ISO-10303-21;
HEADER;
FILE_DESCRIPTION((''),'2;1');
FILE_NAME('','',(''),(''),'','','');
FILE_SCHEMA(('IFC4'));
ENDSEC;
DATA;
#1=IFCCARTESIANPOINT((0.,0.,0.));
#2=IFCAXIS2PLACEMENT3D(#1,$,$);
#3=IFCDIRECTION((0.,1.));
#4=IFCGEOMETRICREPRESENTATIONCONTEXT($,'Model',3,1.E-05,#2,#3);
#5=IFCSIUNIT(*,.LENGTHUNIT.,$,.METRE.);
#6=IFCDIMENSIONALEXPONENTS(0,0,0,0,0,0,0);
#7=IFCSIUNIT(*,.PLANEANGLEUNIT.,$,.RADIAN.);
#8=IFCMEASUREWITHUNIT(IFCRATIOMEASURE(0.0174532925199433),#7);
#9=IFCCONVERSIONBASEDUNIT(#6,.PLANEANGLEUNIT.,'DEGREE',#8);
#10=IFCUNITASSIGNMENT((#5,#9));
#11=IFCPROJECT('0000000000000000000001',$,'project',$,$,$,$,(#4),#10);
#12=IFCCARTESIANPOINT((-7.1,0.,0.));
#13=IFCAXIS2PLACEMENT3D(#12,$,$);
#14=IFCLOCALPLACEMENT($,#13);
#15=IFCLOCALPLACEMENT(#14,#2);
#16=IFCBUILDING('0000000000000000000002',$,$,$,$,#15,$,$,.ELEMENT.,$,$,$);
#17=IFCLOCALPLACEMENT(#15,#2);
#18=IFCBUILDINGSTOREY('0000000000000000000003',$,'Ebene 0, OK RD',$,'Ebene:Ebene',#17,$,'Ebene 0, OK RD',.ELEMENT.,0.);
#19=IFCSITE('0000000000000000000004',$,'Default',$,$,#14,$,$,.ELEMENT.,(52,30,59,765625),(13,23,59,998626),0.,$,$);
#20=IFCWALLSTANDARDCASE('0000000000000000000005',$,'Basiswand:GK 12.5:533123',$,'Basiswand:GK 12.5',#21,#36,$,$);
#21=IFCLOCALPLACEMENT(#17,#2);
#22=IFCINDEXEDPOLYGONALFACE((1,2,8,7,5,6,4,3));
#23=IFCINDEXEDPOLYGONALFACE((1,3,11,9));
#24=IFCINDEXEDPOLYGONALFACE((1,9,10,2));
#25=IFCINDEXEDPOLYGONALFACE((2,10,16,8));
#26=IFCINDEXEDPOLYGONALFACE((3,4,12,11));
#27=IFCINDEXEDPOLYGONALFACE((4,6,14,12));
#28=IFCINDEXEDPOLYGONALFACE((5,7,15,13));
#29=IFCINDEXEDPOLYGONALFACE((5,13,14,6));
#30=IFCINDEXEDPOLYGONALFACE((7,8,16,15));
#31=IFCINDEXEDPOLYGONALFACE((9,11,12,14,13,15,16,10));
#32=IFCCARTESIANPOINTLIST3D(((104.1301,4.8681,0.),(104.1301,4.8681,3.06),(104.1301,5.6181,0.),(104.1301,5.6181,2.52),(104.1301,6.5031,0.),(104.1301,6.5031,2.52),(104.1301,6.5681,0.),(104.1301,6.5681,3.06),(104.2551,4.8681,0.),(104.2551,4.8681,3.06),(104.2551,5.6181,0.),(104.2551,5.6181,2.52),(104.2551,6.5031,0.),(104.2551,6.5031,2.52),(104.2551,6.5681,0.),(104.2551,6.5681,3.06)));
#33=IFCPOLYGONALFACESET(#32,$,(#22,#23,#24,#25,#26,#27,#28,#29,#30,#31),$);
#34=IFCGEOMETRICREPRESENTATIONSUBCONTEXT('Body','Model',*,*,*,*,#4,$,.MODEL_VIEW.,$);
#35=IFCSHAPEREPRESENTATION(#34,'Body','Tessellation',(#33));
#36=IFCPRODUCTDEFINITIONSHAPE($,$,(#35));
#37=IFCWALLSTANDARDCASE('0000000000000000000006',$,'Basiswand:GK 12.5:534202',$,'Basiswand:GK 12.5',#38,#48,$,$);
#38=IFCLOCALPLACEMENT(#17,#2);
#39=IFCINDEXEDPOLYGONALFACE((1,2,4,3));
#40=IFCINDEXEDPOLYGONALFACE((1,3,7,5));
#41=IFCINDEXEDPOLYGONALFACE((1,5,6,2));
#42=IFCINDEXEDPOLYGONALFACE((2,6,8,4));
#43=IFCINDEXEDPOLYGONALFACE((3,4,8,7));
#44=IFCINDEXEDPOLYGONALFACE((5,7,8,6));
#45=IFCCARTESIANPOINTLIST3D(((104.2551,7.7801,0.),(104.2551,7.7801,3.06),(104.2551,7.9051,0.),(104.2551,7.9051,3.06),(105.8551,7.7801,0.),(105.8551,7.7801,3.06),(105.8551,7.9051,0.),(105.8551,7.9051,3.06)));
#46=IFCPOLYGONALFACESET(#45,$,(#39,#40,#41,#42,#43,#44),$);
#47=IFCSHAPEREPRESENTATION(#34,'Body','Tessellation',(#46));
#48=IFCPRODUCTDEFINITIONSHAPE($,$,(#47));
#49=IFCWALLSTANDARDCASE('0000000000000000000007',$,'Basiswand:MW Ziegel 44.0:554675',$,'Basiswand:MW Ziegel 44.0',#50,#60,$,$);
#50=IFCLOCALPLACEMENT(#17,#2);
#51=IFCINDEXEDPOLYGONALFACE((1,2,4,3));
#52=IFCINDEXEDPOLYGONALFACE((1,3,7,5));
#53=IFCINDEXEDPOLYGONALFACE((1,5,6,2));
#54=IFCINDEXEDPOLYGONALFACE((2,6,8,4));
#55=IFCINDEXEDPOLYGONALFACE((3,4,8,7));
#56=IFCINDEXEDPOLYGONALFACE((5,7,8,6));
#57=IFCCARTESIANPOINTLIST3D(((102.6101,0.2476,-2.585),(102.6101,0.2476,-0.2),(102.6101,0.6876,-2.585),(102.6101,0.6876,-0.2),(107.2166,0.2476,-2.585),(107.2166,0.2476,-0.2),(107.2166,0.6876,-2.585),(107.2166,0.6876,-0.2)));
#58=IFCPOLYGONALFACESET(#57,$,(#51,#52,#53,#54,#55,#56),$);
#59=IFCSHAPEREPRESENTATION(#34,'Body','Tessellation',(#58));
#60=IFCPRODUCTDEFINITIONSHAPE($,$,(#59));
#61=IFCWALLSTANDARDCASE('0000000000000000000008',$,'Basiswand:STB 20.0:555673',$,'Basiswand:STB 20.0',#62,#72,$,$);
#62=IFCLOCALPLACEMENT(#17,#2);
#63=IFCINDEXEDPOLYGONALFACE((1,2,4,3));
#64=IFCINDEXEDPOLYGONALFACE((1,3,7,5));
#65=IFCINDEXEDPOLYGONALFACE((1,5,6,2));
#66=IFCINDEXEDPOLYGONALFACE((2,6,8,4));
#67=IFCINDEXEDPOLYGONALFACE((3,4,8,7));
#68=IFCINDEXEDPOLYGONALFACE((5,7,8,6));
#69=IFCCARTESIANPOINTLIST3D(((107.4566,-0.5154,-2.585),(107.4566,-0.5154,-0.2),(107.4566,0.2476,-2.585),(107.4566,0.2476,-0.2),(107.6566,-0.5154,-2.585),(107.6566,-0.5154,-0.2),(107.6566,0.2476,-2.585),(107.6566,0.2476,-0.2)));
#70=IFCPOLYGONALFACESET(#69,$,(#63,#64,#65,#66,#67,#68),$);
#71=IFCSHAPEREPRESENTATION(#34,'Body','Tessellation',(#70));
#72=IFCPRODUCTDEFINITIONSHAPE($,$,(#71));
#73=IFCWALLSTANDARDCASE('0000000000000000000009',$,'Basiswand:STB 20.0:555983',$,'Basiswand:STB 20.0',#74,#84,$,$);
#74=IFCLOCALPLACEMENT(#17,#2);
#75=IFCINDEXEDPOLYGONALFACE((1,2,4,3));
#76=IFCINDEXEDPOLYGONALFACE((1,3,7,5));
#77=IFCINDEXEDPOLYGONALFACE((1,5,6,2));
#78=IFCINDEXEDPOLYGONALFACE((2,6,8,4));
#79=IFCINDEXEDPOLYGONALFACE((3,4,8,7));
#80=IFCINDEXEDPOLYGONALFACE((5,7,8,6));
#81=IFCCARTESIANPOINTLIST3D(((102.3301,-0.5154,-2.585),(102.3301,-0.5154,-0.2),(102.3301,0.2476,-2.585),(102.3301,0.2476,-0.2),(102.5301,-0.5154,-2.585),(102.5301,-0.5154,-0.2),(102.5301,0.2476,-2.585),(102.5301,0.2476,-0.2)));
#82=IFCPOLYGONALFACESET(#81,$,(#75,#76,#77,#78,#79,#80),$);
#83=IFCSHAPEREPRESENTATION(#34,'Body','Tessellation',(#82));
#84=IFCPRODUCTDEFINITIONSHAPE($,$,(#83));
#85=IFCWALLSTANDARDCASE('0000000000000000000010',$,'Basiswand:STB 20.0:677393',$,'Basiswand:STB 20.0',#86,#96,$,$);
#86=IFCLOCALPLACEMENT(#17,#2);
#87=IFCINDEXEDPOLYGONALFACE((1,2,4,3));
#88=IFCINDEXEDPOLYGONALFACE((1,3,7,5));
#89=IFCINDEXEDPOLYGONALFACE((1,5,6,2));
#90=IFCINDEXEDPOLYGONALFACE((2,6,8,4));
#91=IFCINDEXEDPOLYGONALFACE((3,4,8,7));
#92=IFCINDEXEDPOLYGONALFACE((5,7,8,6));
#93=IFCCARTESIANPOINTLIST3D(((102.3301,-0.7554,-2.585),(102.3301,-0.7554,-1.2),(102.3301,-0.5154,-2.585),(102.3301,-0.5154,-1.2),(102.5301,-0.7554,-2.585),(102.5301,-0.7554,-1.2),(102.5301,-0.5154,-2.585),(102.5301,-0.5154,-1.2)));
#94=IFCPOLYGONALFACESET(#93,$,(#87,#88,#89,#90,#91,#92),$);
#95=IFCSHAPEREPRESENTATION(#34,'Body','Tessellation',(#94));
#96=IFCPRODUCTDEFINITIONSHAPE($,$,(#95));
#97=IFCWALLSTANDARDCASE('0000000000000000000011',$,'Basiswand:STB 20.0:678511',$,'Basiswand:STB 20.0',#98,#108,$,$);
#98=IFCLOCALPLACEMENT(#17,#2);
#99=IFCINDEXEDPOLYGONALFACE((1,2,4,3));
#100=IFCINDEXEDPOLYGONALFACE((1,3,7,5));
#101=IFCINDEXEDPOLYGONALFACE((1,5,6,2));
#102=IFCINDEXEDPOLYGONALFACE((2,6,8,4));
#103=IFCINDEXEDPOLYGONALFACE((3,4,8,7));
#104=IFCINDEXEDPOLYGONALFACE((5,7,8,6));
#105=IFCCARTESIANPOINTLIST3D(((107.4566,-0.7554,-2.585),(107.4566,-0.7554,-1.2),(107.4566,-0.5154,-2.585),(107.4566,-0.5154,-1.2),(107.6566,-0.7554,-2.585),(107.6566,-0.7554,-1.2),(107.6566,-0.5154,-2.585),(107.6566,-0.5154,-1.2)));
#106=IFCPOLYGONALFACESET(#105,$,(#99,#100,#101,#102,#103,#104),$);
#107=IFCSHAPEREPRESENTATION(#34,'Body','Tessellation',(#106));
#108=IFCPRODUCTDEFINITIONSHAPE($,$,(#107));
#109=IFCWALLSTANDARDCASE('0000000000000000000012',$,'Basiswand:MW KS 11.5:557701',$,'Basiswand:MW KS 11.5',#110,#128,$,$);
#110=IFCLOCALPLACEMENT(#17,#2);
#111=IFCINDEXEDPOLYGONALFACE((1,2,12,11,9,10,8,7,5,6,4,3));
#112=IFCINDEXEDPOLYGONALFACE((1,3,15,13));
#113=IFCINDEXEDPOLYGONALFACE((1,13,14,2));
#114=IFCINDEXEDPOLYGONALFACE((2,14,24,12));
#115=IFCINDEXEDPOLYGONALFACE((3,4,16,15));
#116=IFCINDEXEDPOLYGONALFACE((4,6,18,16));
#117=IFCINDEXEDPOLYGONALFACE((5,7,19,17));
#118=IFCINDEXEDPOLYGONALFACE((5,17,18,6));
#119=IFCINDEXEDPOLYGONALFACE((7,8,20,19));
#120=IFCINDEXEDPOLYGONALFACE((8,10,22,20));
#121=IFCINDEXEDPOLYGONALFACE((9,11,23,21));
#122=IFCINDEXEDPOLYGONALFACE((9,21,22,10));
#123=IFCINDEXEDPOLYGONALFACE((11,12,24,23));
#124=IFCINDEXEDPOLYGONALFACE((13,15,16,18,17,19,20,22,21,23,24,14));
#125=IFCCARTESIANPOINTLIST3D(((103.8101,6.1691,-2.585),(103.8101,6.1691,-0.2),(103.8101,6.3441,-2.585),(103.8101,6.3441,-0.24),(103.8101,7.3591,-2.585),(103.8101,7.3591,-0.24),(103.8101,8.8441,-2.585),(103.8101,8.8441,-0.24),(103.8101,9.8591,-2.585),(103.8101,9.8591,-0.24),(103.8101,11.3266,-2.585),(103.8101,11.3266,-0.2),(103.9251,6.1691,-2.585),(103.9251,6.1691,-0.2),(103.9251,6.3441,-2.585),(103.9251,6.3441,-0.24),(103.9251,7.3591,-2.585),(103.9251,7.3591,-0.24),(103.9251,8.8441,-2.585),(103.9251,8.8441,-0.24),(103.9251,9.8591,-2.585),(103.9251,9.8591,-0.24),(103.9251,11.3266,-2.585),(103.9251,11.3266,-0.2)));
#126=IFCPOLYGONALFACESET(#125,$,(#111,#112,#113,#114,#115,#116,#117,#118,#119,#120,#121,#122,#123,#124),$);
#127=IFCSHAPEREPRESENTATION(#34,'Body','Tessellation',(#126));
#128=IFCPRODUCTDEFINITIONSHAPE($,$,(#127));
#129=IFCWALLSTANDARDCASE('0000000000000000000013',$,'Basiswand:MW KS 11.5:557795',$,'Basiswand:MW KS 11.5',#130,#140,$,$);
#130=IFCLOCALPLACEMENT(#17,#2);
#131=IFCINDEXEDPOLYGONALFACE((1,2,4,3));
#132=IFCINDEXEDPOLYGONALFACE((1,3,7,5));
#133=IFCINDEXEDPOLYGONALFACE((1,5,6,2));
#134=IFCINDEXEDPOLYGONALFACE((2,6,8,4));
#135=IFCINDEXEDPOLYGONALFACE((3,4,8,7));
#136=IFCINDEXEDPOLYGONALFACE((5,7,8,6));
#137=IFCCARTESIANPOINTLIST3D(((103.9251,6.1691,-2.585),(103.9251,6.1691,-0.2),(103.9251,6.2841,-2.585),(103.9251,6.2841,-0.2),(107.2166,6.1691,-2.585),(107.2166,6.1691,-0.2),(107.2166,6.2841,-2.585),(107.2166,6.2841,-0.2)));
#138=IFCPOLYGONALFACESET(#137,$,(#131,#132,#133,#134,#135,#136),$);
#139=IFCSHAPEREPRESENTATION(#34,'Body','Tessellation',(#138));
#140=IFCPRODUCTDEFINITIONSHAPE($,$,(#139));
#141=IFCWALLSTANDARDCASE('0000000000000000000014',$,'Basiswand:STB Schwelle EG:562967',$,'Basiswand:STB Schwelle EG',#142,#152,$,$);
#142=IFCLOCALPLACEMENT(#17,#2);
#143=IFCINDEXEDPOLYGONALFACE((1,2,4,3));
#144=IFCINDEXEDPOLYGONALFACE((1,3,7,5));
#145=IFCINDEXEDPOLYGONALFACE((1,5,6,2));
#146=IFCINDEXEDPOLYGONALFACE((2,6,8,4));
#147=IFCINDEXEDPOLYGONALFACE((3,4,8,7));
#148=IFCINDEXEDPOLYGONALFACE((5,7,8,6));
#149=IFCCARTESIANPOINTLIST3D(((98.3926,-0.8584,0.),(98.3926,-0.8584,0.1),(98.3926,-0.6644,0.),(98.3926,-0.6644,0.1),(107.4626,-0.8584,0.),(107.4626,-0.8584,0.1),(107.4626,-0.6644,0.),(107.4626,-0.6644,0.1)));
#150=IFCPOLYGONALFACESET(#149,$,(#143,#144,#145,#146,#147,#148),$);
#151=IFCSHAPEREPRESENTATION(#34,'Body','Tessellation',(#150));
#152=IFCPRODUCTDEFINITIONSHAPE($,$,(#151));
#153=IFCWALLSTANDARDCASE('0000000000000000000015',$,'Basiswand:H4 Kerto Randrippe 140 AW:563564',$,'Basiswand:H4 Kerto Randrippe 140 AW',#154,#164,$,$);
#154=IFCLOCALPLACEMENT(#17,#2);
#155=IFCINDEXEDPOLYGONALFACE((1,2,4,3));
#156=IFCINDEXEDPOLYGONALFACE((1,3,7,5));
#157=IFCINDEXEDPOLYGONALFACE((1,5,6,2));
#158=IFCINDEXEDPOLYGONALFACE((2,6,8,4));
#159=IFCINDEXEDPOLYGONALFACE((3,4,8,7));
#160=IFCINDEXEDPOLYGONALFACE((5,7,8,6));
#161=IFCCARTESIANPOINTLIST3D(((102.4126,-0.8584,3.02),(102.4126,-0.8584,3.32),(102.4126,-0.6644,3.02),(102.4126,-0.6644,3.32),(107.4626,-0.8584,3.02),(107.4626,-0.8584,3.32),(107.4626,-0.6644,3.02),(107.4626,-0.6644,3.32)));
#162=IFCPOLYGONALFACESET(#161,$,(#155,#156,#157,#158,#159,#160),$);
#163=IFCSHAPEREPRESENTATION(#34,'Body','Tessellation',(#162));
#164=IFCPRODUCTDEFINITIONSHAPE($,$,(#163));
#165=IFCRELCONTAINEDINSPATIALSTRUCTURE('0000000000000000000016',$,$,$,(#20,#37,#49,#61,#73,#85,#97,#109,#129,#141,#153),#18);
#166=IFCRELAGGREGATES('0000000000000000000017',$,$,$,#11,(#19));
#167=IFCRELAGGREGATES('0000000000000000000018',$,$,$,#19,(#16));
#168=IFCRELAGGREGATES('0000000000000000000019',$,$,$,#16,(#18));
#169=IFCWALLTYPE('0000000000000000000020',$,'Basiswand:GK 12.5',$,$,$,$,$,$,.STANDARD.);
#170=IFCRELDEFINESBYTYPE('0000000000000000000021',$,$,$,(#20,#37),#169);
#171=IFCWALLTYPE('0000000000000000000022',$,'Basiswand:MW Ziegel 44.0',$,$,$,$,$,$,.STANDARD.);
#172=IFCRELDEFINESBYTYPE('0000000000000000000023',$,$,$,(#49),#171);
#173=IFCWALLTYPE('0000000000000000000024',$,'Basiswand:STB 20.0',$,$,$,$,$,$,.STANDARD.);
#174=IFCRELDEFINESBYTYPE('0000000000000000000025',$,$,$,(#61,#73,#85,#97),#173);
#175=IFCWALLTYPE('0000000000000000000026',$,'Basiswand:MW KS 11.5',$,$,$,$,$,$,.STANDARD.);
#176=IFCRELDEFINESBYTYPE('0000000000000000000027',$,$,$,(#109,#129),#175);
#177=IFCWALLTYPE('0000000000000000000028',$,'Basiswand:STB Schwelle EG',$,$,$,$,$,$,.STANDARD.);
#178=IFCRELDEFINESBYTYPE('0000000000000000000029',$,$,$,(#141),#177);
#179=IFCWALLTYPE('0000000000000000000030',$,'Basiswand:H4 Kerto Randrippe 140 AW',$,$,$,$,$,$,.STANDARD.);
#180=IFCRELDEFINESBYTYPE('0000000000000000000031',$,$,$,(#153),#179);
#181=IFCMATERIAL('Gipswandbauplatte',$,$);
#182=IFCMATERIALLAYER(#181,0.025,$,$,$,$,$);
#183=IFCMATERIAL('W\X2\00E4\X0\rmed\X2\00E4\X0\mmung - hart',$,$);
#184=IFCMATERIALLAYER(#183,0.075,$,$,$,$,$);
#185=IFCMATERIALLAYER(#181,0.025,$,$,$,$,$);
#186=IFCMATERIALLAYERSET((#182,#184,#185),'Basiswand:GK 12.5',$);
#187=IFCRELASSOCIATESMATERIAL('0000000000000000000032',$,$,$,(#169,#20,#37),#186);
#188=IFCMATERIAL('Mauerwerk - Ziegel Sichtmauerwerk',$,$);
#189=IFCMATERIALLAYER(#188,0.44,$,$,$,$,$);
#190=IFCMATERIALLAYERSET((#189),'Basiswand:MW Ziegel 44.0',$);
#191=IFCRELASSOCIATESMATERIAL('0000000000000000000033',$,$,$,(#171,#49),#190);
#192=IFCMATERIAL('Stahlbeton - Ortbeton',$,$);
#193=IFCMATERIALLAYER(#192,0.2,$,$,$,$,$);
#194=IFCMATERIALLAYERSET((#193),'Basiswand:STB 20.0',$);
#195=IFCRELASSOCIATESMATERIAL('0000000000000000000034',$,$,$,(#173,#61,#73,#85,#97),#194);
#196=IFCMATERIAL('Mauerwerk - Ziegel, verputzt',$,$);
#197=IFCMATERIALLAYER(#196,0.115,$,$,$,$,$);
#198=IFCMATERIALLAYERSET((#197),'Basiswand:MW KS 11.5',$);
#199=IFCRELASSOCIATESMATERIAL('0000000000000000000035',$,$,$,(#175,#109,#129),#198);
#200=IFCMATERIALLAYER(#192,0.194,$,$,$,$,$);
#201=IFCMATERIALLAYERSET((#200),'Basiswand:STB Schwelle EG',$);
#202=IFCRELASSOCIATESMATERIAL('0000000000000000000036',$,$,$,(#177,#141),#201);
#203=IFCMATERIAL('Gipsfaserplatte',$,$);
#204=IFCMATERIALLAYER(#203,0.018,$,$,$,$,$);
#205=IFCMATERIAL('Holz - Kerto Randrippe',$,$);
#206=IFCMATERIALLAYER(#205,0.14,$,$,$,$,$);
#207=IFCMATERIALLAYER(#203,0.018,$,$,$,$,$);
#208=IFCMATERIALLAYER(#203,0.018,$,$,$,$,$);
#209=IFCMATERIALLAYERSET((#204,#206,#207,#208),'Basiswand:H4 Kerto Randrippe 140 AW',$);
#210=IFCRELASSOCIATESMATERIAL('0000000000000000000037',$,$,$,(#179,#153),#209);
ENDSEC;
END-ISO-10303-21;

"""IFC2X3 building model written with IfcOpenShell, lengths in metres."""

from ifc_helpers import new_model, entity, si_unit, converted_unit, direction, frame, frame_2d, origin, place, context, subcontext, project, spatial, rectangle, extrude, material, layer, layer_set, layer_usage, type_object, element, save


model = new_model("IFC2X3")

# Units and contexts
model_context = context("Model", 3, precision=1e-05, world=origin(), true_north=direction((0.0, 1.0)))
body_context = subcontext(model_context, "Body", "Model", "MODEL_VIEW")
ifc_project = project(units=[si_unit("LENGTHUNIT", "METRE"), converted_unit("PLANEANGLEUNIT", "DEGREE", entity("IfcRatioMeasure", 0.0174532925199433), si_unit("PLANEANGLEUNIT", "RADIAN"), dimensions=[0, 0, 0, 0, 0, 0, 0])], contexts=[model_context])

# Site, building, storey
site_placement = place(None, frame((-7.1, 0.0, 0.0)))
site = spatial("IfcSite", under=ifc_project, at=site_placement, Name="Default", CompositionType="ELEMENT", RefLatitude=(52, 30, 59, 765625), RefLongitude=(13, 23, 59, 998626), RefElevation=0.0)
building_placement = place(site_placement, origin())
building = spatial("IfcBuilding", under=site, at=building_placement, CompositionType="ELEMENT")
storey_placement = place(building_placement, origin())
storey = spatial("IfcBuildingStorey", under=building, at=storey_placement, Name="Ebene 0, OK RD", ObjectType="Ebene:Ebene", LongName="Ebene 0, OK RD", CompositionType="ELEMENT", Elevation=0.0)

# Shared definitions
ifc_material_1 = material(Name="Gipsfaserplatte")

# Shared definitions
ifc_material_2 = material(Name="Gipswandbauplatte")
ifc_layer_1 = layer(ifc_material_2, 0.025)
ifc_material_3 = material(Name="Wärmedämmung - hart")
ifc_layer_2 = layer(ifc_material_3, 0.075)
ifc_layer_3 = layer(ifc_material_2, 0.025)
ifc_layer_set_1 = layer_set([ifc_layer_1, ifc_layer_2, ifc_layer_3], Name="Basiswand:GK 12.5")
wall_type_1 = type_object("IfcWallType", Name="Basiswand:GK 12.5", PredefinedType="STANDARD", material=ifc_layer_set_1)

# Wall, opening
ifc_layer_usage_1 = layer_usage(ifc_layer_set_1, "AXIS2", "NEGATIVE", 0.0625)
wall_1_placement = place(storey_placement, frame((104.1926, 6.5681, 0.0), z_axis=(0.0, 0.0, 1.0), x_axis=(0.0, -1.0, 0.0)))
wall_1 = element("IfcWallStandardCase", 1, at=wall_1_placement, inside=storey, type_object=wall_type_1, material=ifc_layer_usage_1, Name="Basiswand:GK 12.5:533123", ObjectType="Basiswand:GK 12.5", context=body_context, shape_type="SweptSolid", body=[
    extrude(rectangle(XDim=1.7, YDim=0.125, at=frame_2d((0.85, 0.0), x_axis=(-1.0, 0.0))), origin(), (0.0, 0.0, 1.0), 3.06),
])
opening_1_placement = place(wall_1_placement, frame((0.065, -0.0625, 0.0)))
element("IfcOpeningElement", 2, at=opening_1_placement, cuts=wall_1, ObjectType="Opening", context=body_context, shape_type="SweptSolid", body=[
    extrude(rectangle(XDim=2.52, YDim=0.885, at=frame_2d((1.26, 0.4425), x_axis=(1.0, 0.0))), frame((0.0, 0.0, 0.0), z_axis=(0.0, 1.0, 0.0), x_axis=(0.0, 0.0, 1.0)), (0.0, 0.0, 1.0), 0.125),
])

# Walls
ifc_layer_usage_2 = layer_usage(ifc_layer_set_1, "AXIS2", "NEGATIVE", 0.0625)
wall_2_placement = place(storey_placement, frame((104.2551, 7.8426, 0.0)))
element("IfcWallStandardCase", 3, at=wall_2_placement, inside=storey, type_object=wall_type_1, material=ifc_layer_usage_2, Name="Basiswand:GK 12.5:534202", ObjectType="Basiswand:GK 12.5", context=body_context, shape_type="SweptSolid", body=[
    extrude(rectangle(XDim=1.6, YDim=0.125, at=frame_2d((0.8, 0.0), x_axis=(-1.0, 0.0))), origin(), (0.0, 0.0, 1.0), 3.06),
])
ifc_material_4 = material(Name="Mauerwerk - Ziegel Sichtmauerwerk")
ifc_layer_4 = layer(ifc_material_4, 0.44)
ifc_layer_set_2 = layer_set([ifc_layer_4], Name="Basiswand:MW Ziegel 44.0")
ifc_layer_usage_3 = layer_usage(ifc_layer_set_2, "AXIS2", "NEGATIVE", 0.22)
wall_type_2 = type_object("IfcWallType", Name="Basiswand:MW Ziegel 44.0", PredefinedType="STANDARD", material=ifc_layer_set_2)
wall_3_placement = place(storey_placement, frame((107.2166, 0.4676, -2.585), z_axis=(0.0, 0.0, 1.0), x_axis=(-1.0, 0.0, 0.0)))
element("IfcWallStandardCase", 4, at=wall_3_placement, inside=storey, type_object=wall_type_2, material=ifc_layer_usage_3, Name="Basiswand:MW Ziegel 44.0:554675", ObjectType="Basiswand:MW Ziegel 44.0", context=body_context, shape_type="SweptSolid", body=[
    extrude(rectangle(XDim=4.6065, YDim=0.44, at=frame_2d((2.3033, 0.0), x_axis=(-1.0, 0.0))), origin(), (0.0, 0.0, 1.0), 2.385),
])
ifc_material_5 = material(Name="Stahlbeton - Ortbeton")
ifc_layer_5 = layer(ifc_material_5, 0.2)
ifc_layer_set_3 = layer_set([ifc_layer_5], Name="Basiswand:STB 20.0")
ifc_layer_usage_4 = layer_usage(ifc_layer_set_3, "AXIS2", "NEGATIVE", 0.1)
wall_type_3 = type_object("IfcWallType", Name="Basiswand:STB 20.0", PredefinedType="STANDARD", material=ifc_layer_set_3)
wall_4_placement = place(storey_placement, frame((107.5566, 0.2476, -2.585), z_axis=(0.0, 0.0, 1.0), x_axis=(0.0, -1.0, 0.0)))
element("IfcWallStandardCase", 5, at=wall_4_placement, inside=storey, type_object=wall_type_3, material=ifc_layer_usage_4, Name="Basiswand:STB 20.0:555673", ObjectType="Basiswand:STB 20.0", context=body_context, shape_type="SweptSolid", body=[
    extrude(rectangle(XDim=0.763, YDim=0.2, at=frame_2d((0.3815, 0.0), x_axis=(-1.0, 0.0))), origin(), (0.0, 0.0, 1.0), 2.385),
])
ifc_layer_usage_5 = layer_usage(ifc_layer_set_3, "AXIS2", "NEGATIVE", 0.1)
wall_5_placement = place(storey_placement, frame((102.4301, 0.2476, -2.585), z_axis=(0.0, 0.0, 1.0), x_axis=(0.0, -1.0, 0.0)))
element("IfcWallStandardCase", 6, at=wall_5_placement, inside=storey, type_object=wall_type_3, material=ifc_layer_usage_5, Name="Basiswand:STB 20.0:555983", ObjectType="Basiswand:STB 20.0", context=body_context, shape_type="SweptSolid", body=[
    extrude(rectangle(XDim=0.763, YDim=0.2, at=frame_2d((0.3815, 0.0), x_axis=(-1.0, 0.0))), origin(), (0.0, 0.0, 1.0), 2.385),
])
ifc_layer_usage_6 = layer_usage(ifc_layer_set_3, "AXIS2", "NEGATIVE", 0.1)
wall_6_placement = place(storey_placement, frame((102.4301, -0.5154, -2.585), z_axis=(0.0, 0.0, 1.0), x_axis=(0.0, -1.0, 0.0)))
element("IfcWallStandardCase", 7, at=wall_6_placement, inside=storey, type_object=wall_type_3, material=ifc_layer_usage_6, Name="Basiswand:STB 20.0:677393", ObjectType="Basiswand:STB 20.0", context=body_context, shape_type="SweptSolid", body=[
    extrude(rectangle(XDim=0.24, YDim=0.2, at=frame_2d((0.12, 0.0), x_axis=(-1.0, 0.0))), origin(), (0.0, 0.0, 1.0), 1.385),
])
ifc_layer_usage_7 = layer_usage(ifc_layer_set_3, "AXIS2", "NEGATIVE", 0.1)
wall_7_placement = place(storey_placement, frame((107.5566, -0.5154, -2.585), z_axis=(0.0, 0.0, 1.0), x_axis=(0.0, -1.0, 0.0)))
element("IfcWallStandardCase", 8, at=wall_7_placement, inside=storey, type_object=wall_type_3, material=ifc_layer_usage_7, Name="Basiswand:STB 20.0:678511", ObjectType="Basiswand:STB 20.0", context=body_context, shape_type="SweptSolid", body=[
    extrude(rectangle(XDim=0.24, YDim=0.2, at=frame_2d((0.12, 0.0), x_axis=(-1.0, 0.0))), origin(), (0.0, 0.0, 1.0), 1.385),
])

# Wall, openings
ifc_material_6 = material(Name="Mauerwerk - Ziegel, verputzt")
ifc_layer_6 = layer(ifc_material_6, 0.115)
ifc_layer_set_4 = layer_set([ifc_layer_6], Name="Basiswand:MW KS 11.5")
ifc_layer_usage_8 = layer_usage(ifc_layer_set_4, "AXIS2", "POSITIVE", -0.0575)
wall_type_4 = type_object("IfcWallType", Name="Basiswand:MW KS 11.5", PredefinedType="STANDARD", material=ifc_layer_set_4)
wall_8_placement = place(storey_placement, frame((103.8676, 6.1691, -2.585), z_axis=(0.0, 0.0, 1.0), x_axis=(0.0, 1.0, 0.0)))
wall_8 = element("IfcWallStandardCase", 9, at=wall_8_placement, inside=storey, type_object=wall_type_4, material=ifc_layer_usage_8, Name="Basiswand:MW KS 11.5:557701", ObjectType="Basiswand:MW KS 11.5", context=body_context, shape_type="SweptSolid", body=[
    extrude(rectangle(XDim=5.1575, YDim=0.115, at=frame_2d((2.5787, 0.0), x_axis=(-1.0, 0.0))), origin(), (0.0, 0.0, 1.0), 2.385),
])
opening_2_placement = place(wall_8_placement, frame((3.69, 0.0575, 0.0)))
element("IfcOpeningElement", 10, at=opening_2_placement, cuts=wall_8, ObjectType="Opening", context=body_context, shape_type="SweptSolid", body=[
    extrude(rectangle(XDim=2.345, YDim=1.015, at=frame_2d((1.1725, 0.5075), x_axis=(1.0, 0.0))), frame((0.0, 0.0, 0.0), z_axis=(0.0, -1.0, 0.0), x_axis=(0.0, 0.0, 1.0)), (0.0, 0.0, 1.0), 0.115),
])
opening_3_placement = place(wall_8_placement, frame((1.19, 0.0575, 0.0)))
element("IfcOpeningElement", 11, at=opening_3_placement, cuts=wall_8, ObjectType="Opening", context=body_context, shape_type="SweptSolid", body=[
    extrude(rectangle(XDim=2.345, YDim=1.015, at=frame_2d((1.1725, 0.5075), x_axis=(1.0, 0.0))), frame((0.0, 0.0, 0.0), z_axis=(0.0, -1.0, 0.0), x_axis=(0.0, 0.0, 1.0)), (0.0, 0.0, 1.0), 0.115),
])

# Walls
ifc_layer_usage_9 = layer_usage(ifc_layer_set_4, "AXIS2", "NEGATIVE", 0.0575)
wall_9_placement = place(storey_placement, frame((103.9251, 6.2266, -2.585)))
element("IfcWallStandardCase", 12, at=wall_9_placement, inside=storey, type_object=wall_type_4, material=ifc_layer_usage_9, Name="Basiswand:MW KS 11.5:557795", ObjectType="Basiswand:MW KS 11.5", context=body_context, shape_type="SweptSolid", body=[
    extrude(rectangle(XDim=3.2915, YDim=0.115, at=frame_2d((1.6457, 0.0), x_axis=(-1.0, 0.0))), origin(), (0.0, 0.0, 1.0), 2.385),
])
ifc_layer_7 = layer(ifc_material_5, 0.194)
ifc_layer_set_5 = layer_set([ifc_layer_7], Name="Basiswand:STB Schwelle EG")
ifc_layer_usage_10 = layer_usage(ifc_layer_set_5, "AXIS2", "NEGATIVE", 0.097)
wall_type_5 = type_object("IfcWallType", Name="Basiswand:STB Schwelle EG", PredefinedType="STANDARD", material=ifc_layer_set_5)
wall_10_placement = place(storey_placement, frame((107.4626, -0.7614, 0.0), z_axis=(0.0, 0.0, 1.0), x_axis=(-1.0, 0.0, 0.0)))
element("IfcWallStandardCase", 13, at=wall_10_placement, inside=storey, type_object=wall_type_5, material=ifc_layer_usage_10, Name="Basiswand:STB Schwelle EG:562967", ObjectType="Basiswand:STB Schwelle EG", context=body_context, shape_type="SweptSolid", body=[
    extrude(rectangle(XDim=9.07, YDim=0.194, at=frame_2d((4.535, 0.0), x_axis=(-1.0, 0.0))), origin(), (0.0, 0.0, 1.0), 0.1),
])
ifc_layer_8 = layer(ifc_material_1, 0.018)
ifc_material_7 = material(Name="Holz - Kerto Randrippe")
ifc_layer_9 = layer(ifc_material_7, 0.14)
ifc_layer_10 = layer(ifc_material_1, 0.018)
ifc_layer_11 = layer(ifc_material_1, 0.018)
ifc_layer_set_6 = layer_set([ifc_layer_8, ifc_layer_9, ifc_layer_10, ifc_layer_11], Name="Basiswand:H4 Kerto Randrippe 140 AW")
ifc_layer_usage_11 = layer_usage(ifc_layer_set_6, "AXIS2", "NEGATIVE", 0.097)
wall_type_6 = type_object("IfcWallType", Name="Basiswand:H4 Kerto Randrippe 140 AW", PredefinedType="STANDARD", material=ifc_layer_set_6)
wall_11_placement = place(storey_placement, frame((107.4626, -0.7614, 3.02), z_axis=(0.0, 0.0, 1.0), x_axis=(-1.0, 0.0, 0.0)))
element("IfcWallStandardCase", 14, at=wall_11_placement, inside=storey, type_object=wall_type_6, material=ifc_layer_usage_11, Name="Basiswand:H4 Kerto Randrippe 140 AW:563564", ObjectType="Basiswand:H4 Kerto Randrippe 140 AW", context=body_context, shape_type="SweptSolid", body=[
    extrude(rectangle(XDim=5.05, YDim=0.194, at=frame_2d((2.525, 0.0), x_axis=(-1.0, 0.0))), origin(), (0.0, 0.0, 1.0), 0.3),
])

save(model, "model.ifc")
